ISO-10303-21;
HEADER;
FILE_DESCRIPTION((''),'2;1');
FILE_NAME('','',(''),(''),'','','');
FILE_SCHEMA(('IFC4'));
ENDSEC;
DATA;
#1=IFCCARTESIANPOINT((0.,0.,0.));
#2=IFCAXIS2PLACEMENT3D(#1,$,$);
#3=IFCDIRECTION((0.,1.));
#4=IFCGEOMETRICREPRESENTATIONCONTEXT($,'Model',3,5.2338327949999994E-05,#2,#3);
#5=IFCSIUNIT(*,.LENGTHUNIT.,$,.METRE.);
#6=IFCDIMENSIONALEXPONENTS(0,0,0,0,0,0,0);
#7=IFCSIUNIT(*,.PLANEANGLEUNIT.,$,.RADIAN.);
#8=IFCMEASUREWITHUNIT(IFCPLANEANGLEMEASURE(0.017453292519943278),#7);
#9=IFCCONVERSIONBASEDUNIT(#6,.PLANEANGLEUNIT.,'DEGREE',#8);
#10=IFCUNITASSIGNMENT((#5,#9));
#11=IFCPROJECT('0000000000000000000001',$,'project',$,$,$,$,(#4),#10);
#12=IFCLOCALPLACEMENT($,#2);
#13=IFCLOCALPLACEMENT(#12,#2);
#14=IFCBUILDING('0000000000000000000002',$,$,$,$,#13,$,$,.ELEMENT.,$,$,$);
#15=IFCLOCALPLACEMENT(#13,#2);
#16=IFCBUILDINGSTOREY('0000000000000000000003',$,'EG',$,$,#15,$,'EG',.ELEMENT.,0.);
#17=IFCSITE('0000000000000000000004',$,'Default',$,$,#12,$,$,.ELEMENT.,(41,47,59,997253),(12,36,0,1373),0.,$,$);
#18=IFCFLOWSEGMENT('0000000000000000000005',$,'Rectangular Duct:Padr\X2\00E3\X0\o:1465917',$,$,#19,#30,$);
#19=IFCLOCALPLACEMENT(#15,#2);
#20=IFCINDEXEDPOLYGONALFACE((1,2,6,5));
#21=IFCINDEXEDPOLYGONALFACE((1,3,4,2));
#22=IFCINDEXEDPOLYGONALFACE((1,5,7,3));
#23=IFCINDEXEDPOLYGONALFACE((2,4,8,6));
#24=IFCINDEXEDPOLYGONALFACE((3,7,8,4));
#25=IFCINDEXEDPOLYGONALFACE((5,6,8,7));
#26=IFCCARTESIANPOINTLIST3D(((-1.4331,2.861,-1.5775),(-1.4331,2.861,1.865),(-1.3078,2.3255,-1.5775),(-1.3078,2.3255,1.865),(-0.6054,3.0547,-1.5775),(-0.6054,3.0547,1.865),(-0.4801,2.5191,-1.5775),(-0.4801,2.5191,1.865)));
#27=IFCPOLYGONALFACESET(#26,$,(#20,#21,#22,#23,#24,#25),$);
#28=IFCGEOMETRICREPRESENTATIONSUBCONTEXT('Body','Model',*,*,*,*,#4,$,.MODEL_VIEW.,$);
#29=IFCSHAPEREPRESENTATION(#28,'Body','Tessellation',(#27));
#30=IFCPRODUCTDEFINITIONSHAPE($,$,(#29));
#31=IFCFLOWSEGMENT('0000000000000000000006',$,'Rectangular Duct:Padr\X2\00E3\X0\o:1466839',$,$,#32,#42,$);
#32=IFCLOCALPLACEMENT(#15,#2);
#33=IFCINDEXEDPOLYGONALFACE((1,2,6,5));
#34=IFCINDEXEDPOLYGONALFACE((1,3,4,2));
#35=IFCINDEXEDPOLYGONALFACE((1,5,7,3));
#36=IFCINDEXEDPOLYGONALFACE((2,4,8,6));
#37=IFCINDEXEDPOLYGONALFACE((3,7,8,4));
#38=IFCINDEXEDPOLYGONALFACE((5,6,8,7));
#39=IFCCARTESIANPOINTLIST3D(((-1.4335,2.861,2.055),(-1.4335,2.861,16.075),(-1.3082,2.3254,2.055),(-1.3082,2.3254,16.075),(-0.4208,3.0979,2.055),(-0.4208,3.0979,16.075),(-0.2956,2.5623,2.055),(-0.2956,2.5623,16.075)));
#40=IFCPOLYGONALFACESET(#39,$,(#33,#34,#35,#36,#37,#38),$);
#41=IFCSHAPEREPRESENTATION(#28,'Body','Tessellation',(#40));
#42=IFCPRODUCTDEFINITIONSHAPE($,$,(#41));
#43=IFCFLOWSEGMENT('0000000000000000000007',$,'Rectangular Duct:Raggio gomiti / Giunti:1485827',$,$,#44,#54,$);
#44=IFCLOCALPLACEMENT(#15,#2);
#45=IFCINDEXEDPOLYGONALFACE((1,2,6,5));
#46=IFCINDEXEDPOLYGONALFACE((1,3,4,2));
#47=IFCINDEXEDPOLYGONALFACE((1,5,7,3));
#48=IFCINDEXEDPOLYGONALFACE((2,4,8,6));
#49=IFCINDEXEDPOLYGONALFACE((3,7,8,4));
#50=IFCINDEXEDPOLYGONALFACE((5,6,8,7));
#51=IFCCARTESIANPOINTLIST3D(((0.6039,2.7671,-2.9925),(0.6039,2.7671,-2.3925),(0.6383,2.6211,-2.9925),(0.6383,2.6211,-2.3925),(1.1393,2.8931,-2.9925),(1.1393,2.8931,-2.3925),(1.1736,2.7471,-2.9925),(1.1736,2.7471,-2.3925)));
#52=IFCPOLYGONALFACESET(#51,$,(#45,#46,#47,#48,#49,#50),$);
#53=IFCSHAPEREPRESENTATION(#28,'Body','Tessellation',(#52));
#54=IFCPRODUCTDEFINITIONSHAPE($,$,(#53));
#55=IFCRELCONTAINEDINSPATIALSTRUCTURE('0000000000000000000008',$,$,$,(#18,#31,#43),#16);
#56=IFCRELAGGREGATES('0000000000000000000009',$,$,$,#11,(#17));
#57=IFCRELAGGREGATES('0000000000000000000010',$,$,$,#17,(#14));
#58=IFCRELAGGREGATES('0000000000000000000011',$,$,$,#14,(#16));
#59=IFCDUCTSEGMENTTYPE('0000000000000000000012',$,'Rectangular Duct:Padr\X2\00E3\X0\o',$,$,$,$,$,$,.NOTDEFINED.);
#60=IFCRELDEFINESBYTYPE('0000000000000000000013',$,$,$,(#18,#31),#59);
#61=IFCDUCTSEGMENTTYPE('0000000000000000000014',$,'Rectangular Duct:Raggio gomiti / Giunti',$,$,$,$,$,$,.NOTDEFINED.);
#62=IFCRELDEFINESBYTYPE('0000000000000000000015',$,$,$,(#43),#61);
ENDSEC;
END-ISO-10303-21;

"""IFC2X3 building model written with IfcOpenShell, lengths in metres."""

from ifc_helpers import new_model, entity, si_unit, converted_unit, direction, frame, frame_2d, origin, origin_2d_with_axis, place, context, subcontext, project, spatial, rectangle, extrude, type_object, element, save


model = new_model("IFC2X3")

# Units and contexts
model_context = context("Model", 3, precision=5.2338327949999994e-05, world=origin(), true_north=direction((0.0, 1.0)))
body_context = subcontext(model_context, "Body", "Model", "MODEL_VIEW")
ifc_project = project(units=[si_unit("LENGTHUNIT", "METRE"), converted_unit("PLANEANGLEUNIT", "DEGREE", entity("IfcPlaneAngleMeasure", 0.017453292519943278), si_unit("PLANEANGLEUNIT", "RADIAN"), dimensions=[0, 0, 0, 0, 0, 0, 0])], contexts=[model_context])

# Site, building, storey
site_placement = place(None, origin())
site = spatial("IfcSite", under=ifc_project, at=site_placement, Name="Default", CompositionType="ELEMENT", RefLatitude=(41, 47, 59, 997253), RefLongitude=(12, 36, 0, 1373), RefElevation=0.0)
building_placement = place(site_placement, origin())
building = spatial("IfcBuilding", under=site, at=building_placement, CompositionType="ELEMENT")
storey_placement = place(building_placement, origin())
storey = spatial("IfcBuildingStorey", under=building, at=storey_placement, Name="EG", LongName="EG", CompositionType="ELEMENT", Elevation=0.0)

# Flow segments
duct_segment_type_1 = type_object("IfcDuctSegmentType", Name="Rectangular Duct:Padrão", PredefinedType="NOTDEFINED")
flow_segment_1_placement = place(storey_placement, origin())
element("IfcFlowSegment", 1, at=flow_segment_1_placement, inside=storey, type_object=duct_segment_type_1, Name="Rectangular Duct:Padrão:1465917", context=body_context, shape_type="SweptSolid", body=[
    extrude(rectangle(XDim=0.55, YDim=0.85, at=frame_2d((0.0, 0.0), x_axis=(1.0, 0.0))), frame((-0.9566, 2.6901, -1.5775), z_axis=(0.0, 0.0, 1.0), x_axis=(0.227805, -0.973707, 0.0)), (0.0, 0.0, 1.0), 3.4425),
])
flow_segment_2_placement = place(storey_placement, origin())
element("IfcFlowSegment", 2, at=flow_segment_2_placement, inside=storey, type_object=duct_segment_type_1, Name="Rectangular Duct:Padrão:1466839", context=body_context, shape_type="SweptSolid", body=[
    extrude(rectangle(XDim=0.55, YDim=1.04, at=frame_2d((0.0, 0.0), x_axis=(1.0, 0.0))), frame((-0.8645, 2.7116, 2.055), z_axis=(0.0, 0.0, 1.0), x_axis=(-0.227772, 0.973714, 0.0)), (0.0, 0.0, 1.0), 14.02),
])

# Flow segment
duct_segment_type_2 = type_object("IfcDuctSegmentType", Name="Rectangular Duct:Raggio gomiti / Giunti", PredefinedType="NOTDEFINED")
flow_segment_3_placement = place(storey_placement, origin())
element("IfcFlowSegment", 3, at=flow_segment_3_placement, inside=storey, type_object=duct_segment_type_2, Name="Rectangular Duct:Raggio gomiti / Giunti:1485827", context=body_context, shape_type="SweptSolid", body=[
    extrude(rectangle(XDim=0.15, YDim=0.55, at=origin_2d_with_axis()), frame((0.8888, 2.7571, -2.9925), z_axis=(0.0, 0.0, 1.0), x_axis=(0.229116, -0.973399, 0.0)), (0.0, 0.0, 1.0), 0.6),
])

save(model, "model.ifc")
